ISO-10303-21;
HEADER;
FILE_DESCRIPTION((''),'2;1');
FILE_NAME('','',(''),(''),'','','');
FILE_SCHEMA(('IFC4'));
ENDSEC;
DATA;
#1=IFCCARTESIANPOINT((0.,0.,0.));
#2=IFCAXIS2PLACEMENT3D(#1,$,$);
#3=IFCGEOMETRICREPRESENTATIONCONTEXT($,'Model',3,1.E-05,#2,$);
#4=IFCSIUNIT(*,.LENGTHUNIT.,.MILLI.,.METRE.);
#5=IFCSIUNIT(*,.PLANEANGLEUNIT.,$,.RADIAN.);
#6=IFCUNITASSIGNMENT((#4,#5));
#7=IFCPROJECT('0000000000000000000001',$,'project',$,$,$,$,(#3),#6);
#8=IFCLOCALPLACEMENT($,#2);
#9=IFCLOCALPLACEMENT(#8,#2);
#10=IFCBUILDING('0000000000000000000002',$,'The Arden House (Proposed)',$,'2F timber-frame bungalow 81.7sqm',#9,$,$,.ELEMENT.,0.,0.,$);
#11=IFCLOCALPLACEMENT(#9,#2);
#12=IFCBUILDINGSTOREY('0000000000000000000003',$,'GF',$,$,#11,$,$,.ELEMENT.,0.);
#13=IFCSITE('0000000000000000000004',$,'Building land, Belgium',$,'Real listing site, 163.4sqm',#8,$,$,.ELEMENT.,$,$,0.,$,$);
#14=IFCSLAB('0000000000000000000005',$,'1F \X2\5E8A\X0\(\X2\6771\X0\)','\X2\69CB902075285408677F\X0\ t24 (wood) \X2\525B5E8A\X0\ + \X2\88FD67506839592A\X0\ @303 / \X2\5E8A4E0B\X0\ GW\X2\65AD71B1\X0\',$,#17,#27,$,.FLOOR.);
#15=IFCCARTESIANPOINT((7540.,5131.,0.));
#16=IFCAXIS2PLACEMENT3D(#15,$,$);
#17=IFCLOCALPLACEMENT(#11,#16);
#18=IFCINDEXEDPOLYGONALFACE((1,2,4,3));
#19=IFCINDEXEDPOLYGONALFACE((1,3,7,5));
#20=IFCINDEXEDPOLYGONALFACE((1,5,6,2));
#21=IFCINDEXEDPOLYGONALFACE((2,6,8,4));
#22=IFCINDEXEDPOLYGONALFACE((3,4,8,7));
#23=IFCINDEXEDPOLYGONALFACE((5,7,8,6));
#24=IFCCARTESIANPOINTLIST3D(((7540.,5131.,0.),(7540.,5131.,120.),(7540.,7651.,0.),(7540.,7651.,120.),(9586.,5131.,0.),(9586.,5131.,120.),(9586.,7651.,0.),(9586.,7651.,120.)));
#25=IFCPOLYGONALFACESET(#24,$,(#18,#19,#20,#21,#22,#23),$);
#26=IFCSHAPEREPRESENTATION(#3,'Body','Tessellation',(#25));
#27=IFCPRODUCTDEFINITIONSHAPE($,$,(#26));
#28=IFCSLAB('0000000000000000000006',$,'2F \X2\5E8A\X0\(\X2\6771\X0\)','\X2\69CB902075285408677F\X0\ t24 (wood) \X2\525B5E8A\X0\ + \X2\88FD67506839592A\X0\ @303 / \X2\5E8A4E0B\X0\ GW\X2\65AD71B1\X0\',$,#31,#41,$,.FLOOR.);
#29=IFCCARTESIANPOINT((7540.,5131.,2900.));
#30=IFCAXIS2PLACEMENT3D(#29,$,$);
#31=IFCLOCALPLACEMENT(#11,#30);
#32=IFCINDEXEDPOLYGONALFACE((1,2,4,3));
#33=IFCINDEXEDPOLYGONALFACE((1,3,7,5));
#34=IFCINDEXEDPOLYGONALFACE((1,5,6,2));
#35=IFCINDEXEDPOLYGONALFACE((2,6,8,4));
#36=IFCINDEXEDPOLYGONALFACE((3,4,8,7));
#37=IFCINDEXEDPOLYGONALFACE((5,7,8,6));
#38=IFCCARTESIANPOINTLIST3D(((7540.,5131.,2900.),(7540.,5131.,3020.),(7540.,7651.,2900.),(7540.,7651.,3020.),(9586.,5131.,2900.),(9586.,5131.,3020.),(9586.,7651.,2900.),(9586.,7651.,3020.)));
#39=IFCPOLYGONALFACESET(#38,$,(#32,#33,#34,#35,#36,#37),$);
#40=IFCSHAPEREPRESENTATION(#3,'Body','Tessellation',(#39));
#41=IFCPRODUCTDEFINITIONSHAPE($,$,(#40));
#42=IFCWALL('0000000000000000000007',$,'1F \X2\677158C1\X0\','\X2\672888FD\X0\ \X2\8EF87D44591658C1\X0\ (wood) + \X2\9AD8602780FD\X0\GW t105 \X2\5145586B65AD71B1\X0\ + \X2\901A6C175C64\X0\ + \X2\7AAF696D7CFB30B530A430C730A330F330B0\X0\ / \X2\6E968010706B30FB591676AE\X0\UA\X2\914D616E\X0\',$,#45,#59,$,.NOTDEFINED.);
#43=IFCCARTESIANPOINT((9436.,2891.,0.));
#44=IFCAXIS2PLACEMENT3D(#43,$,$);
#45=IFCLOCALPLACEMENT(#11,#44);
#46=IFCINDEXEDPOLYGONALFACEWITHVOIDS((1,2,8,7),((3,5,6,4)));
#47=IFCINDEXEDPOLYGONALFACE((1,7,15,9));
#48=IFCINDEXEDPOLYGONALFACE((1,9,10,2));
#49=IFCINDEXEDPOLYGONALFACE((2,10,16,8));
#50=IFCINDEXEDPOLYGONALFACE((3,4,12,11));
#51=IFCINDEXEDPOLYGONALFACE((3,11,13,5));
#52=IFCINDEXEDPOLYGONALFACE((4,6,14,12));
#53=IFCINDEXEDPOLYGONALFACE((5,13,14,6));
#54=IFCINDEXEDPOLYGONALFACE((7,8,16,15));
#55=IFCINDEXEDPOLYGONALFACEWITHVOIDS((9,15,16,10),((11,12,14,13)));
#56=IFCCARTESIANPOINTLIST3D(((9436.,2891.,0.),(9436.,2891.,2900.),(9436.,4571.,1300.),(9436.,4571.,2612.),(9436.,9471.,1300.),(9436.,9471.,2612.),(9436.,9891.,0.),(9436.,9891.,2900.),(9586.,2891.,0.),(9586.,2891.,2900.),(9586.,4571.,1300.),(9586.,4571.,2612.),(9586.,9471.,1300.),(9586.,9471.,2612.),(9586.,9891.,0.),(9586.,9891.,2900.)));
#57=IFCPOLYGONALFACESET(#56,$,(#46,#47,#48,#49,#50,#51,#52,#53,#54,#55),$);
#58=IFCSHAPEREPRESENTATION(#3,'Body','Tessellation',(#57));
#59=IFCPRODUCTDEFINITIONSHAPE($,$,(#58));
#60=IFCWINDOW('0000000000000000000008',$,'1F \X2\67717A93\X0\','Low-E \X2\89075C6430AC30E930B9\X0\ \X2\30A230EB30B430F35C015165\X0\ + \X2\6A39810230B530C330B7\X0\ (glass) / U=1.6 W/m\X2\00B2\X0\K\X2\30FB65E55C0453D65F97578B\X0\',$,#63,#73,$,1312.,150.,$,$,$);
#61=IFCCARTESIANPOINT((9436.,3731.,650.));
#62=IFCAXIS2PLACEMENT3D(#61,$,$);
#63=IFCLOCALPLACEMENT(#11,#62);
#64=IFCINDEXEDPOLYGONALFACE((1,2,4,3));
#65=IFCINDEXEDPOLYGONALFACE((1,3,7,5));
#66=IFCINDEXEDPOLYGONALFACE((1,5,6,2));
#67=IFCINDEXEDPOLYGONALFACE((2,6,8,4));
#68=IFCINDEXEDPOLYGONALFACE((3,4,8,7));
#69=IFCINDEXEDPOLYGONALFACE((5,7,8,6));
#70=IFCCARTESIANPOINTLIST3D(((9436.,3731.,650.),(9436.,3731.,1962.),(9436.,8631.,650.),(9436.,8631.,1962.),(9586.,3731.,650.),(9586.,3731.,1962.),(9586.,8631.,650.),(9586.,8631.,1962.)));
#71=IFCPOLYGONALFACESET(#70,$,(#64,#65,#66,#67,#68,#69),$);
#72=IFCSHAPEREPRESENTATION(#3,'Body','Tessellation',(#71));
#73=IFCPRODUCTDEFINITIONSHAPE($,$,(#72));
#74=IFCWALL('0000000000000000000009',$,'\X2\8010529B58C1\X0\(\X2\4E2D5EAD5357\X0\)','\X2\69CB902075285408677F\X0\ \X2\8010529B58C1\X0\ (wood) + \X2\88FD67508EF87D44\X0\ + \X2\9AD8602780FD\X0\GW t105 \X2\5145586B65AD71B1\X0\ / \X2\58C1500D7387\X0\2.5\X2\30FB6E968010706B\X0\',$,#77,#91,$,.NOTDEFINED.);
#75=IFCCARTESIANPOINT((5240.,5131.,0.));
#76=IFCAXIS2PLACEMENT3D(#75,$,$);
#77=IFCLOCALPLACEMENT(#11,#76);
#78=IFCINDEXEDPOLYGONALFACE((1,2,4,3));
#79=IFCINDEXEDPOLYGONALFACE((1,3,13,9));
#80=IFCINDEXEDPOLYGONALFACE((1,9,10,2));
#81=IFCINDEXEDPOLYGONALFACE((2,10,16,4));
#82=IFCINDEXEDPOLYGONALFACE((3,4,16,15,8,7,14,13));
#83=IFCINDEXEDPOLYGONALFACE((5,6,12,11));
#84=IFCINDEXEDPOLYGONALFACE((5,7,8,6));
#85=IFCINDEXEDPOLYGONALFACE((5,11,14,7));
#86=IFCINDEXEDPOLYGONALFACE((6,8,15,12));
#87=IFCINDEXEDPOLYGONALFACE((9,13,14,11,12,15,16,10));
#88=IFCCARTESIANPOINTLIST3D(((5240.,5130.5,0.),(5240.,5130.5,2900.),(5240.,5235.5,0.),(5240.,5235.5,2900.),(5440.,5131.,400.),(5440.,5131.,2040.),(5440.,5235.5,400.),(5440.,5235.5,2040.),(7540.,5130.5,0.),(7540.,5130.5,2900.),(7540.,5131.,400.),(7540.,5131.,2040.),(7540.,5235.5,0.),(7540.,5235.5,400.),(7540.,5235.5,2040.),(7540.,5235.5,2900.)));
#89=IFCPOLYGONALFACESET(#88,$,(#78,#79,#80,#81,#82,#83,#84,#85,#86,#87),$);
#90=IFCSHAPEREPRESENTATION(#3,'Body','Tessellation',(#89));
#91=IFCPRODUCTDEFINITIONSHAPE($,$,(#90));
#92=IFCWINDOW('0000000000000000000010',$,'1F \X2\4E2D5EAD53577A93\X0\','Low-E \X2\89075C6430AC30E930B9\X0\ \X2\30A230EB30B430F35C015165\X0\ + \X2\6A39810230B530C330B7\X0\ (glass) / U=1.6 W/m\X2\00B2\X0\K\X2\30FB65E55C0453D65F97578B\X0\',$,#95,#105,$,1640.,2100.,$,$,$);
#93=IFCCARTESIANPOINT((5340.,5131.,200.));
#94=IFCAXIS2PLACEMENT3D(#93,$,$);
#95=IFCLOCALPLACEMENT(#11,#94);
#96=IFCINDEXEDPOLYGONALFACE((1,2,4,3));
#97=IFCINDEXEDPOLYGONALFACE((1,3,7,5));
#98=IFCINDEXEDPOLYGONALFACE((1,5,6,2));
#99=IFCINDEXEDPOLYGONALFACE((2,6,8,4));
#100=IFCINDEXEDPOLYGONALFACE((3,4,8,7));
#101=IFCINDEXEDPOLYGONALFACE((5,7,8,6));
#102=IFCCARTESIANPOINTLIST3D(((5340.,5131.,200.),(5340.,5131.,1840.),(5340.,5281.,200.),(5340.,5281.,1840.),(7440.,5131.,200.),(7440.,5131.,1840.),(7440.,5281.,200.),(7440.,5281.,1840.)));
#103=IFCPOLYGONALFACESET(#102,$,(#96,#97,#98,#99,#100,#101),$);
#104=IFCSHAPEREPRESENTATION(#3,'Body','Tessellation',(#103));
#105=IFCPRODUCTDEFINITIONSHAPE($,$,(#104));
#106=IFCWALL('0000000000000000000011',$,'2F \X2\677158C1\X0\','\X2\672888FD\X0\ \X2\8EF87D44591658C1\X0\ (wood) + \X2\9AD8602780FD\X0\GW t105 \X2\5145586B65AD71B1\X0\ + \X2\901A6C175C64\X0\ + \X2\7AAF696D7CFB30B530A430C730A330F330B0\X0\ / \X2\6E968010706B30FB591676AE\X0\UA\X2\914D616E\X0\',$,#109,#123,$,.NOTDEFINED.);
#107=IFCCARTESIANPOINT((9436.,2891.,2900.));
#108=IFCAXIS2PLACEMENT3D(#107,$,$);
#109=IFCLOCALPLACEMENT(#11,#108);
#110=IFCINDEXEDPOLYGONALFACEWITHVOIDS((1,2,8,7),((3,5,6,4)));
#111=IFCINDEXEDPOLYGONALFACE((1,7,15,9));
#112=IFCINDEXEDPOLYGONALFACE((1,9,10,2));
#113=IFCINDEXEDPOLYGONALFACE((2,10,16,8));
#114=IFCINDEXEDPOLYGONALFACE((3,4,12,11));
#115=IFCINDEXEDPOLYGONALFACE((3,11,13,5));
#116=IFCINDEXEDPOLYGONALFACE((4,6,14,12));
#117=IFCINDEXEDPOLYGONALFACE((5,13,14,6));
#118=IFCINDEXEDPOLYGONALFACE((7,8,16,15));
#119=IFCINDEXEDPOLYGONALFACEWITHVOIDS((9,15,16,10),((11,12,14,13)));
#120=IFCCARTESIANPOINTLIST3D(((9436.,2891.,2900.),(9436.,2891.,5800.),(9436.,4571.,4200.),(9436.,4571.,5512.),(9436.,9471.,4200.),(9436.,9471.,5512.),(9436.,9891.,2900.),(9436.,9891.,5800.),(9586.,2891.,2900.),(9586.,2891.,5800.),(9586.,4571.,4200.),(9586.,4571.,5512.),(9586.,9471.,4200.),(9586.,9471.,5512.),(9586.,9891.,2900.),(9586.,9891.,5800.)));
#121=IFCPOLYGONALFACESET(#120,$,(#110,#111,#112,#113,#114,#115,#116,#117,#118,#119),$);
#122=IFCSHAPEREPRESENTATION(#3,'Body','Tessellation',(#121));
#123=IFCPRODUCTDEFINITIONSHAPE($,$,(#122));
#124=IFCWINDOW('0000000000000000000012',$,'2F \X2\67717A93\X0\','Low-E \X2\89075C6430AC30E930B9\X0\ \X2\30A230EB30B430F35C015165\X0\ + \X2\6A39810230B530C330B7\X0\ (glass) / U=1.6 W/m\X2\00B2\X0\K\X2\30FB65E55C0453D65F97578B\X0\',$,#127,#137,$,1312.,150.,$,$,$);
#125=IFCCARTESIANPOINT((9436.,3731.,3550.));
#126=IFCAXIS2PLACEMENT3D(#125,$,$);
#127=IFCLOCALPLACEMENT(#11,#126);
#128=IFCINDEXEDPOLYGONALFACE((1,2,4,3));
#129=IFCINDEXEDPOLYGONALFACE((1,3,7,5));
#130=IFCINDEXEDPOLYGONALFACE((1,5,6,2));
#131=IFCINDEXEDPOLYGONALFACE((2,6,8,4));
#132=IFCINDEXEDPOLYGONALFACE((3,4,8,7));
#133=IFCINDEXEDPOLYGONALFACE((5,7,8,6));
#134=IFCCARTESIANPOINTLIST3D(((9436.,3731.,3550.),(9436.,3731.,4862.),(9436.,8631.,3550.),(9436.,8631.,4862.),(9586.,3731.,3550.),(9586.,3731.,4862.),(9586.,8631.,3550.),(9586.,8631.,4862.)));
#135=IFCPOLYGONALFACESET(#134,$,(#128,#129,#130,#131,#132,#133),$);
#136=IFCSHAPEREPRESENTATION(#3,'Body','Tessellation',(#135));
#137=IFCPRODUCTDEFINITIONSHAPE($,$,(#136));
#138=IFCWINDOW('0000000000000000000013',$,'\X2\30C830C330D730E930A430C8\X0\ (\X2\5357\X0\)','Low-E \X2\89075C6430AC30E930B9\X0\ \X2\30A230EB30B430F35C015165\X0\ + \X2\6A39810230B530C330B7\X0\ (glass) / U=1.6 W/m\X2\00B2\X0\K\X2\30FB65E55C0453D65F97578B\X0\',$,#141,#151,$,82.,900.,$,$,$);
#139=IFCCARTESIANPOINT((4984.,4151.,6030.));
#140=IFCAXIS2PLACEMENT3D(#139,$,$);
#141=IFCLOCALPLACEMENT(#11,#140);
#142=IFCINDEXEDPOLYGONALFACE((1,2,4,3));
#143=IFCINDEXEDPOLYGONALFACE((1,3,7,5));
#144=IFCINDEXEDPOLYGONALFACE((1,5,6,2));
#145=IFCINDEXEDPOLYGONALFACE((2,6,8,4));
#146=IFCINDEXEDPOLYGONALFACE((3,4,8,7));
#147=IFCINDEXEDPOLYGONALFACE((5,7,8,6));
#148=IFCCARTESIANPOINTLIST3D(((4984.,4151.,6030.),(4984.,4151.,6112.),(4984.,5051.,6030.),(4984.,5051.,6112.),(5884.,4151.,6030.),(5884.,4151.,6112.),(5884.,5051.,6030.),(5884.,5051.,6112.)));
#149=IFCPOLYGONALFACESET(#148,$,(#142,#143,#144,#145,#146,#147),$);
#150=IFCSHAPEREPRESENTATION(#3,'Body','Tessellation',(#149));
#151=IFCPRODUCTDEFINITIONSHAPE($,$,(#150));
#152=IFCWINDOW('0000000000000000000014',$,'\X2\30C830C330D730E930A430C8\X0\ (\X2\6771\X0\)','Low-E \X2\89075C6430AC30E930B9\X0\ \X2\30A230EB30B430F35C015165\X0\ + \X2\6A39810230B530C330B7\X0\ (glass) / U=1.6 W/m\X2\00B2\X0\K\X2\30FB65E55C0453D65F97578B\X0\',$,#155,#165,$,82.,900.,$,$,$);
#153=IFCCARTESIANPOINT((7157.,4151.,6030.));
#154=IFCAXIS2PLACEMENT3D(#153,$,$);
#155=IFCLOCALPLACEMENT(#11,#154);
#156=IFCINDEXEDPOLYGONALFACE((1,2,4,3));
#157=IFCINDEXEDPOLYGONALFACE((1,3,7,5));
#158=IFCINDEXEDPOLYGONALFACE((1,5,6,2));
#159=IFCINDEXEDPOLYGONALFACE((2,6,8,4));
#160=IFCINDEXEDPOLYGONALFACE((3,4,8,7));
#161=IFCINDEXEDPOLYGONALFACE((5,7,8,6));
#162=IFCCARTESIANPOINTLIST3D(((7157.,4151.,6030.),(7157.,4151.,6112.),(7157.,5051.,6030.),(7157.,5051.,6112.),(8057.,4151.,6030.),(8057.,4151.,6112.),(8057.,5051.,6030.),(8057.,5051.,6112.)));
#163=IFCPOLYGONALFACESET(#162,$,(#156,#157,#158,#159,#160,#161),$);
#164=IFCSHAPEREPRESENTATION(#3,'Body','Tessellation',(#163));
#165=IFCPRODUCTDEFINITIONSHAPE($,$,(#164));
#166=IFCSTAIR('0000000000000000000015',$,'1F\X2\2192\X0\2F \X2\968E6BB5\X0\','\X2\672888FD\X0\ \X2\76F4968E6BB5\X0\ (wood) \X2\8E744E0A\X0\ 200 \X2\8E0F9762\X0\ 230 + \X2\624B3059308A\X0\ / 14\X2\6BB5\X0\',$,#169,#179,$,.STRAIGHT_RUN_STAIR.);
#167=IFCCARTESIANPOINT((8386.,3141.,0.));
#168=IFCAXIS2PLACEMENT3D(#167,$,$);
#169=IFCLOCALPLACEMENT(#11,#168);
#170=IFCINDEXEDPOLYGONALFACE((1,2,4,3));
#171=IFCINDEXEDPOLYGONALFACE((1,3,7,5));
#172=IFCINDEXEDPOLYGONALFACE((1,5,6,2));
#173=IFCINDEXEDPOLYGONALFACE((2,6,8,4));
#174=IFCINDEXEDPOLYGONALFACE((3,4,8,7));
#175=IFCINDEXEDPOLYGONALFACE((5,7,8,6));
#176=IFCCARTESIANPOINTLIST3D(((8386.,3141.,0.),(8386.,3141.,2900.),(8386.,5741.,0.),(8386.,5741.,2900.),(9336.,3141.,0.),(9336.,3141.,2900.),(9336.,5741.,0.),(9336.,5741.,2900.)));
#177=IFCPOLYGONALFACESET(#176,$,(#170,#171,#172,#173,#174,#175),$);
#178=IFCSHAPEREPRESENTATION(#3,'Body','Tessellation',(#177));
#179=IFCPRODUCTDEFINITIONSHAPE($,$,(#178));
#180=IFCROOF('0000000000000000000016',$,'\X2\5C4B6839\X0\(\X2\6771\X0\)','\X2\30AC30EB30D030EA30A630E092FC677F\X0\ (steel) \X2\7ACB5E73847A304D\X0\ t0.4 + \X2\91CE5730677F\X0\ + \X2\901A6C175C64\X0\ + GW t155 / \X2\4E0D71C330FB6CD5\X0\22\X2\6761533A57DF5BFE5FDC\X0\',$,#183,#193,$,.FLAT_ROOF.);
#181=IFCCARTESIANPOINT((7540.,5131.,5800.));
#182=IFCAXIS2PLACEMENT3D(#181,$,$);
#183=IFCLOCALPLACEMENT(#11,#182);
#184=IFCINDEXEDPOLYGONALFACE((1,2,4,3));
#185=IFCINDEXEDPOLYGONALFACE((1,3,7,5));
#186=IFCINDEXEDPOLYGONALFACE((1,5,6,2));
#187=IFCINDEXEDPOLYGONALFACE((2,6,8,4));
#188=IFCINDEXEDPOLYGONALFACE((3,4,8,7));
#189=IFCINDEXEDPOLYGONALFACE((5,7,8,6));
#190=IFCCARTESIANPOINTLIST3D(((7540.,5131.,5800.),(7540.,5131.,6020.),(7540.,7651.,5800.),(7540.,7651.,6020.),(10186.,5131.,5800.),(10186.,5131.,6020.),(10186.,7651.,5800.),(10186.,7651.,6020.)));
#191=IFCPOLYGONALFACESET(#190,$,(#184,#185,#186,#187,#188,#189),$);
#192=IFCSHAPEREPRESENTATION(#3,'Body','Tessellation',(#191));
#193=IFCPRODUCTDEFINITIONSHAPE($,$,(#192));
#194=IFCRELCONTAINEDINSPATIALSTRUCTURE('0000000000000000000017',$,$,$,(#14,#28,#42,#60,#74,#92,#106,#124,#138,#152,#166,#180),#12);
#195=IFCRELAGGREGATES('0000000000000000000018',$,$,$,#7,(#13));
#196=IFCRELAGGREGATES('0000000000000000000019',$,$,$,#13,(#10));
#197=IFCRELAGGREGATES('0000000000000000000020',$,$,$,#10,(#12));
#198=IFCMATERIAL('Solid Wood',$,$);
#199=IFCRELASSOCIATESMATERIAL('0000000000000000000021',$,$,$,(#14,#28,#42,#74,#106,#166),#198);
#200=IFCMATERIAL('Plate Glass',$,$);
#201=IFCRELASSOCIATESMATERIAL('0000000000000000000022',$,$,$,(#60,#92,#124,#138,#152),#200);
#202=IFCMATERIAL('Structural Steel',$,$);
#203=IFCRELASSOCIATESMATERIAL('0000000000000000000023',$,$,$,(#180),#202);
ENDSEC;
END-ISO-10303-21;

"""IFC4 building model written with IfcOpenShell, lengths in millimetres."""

from ifc_helpers import new_model, si_unit, frame, frame_2d, origin, place, context, project, spatial, rectangle, extrude, material, element, fill, save


model = new_model("IFC4")

# Units and contexts
model_context = context("Model", 3, precision=1e-05, world=origin())
ifc_project = project(units=[si_unit("LENGTHUNIT", "METRE", prefix="MILLI"), si_unit("PLANEANGLEUNIT", "RADIAN")], contexts=[model_context])

# Site, building, storey
site_placement = place(None, origin())
site = spatial("IfcSite", under=ifc_project, at=site_placement, Name="Building land, Belgium", ObjectType="Real listing site, 163.4sqm", CompositionType="ELEMENT", RefElevation=0.0)
building_placement = place(site_placement, origin())
building = spatial("IfcBuilding", under=site, at=building_placement, Name="The Arden House (Proposed)", ObjectType="2F timber-frame bungalow 81.7sqm", CompositionType="ELEMENT", ElevationOfRefHeight=0.0, ElevationOfTerrain=0.0)
storey_placement = place(building_placement, origin())
storey = spatial("IfcBuildingStorey", under=building, at=storey_placement, Name="GF", CompositionType="ELEMENT", Elevation=0.0)

# Slabs
ifc_material_1 = material(Name="Solid Wood")
slab_1_placement = place(storey_placement, frame((7540.0, 5131.0, 0.0)))
element("IfcSlab", 1, at=slab_1_placement, inside=storey, material=ifc_material_1, Name="1F 床(東)", Description="構造用合板 t24 (wood) 剛床 + 製材根太 @303 / 床下 GW断熱", PredefinedType="FLOOR", context=model_context, shape_type="SweptSolid", body=[
    extrude(rectangle(XDim=2046.0, YDim=2520.0, at=frame_2d((1023.0, 1260.0))), frame((7540.0, 5131.0, 0.0)), (0.0, 0.0, 1.0), 120.0),
])
slab_2_placement = place(storey_placement, frame((7540.0, 5131.0, 2900.0)))
element("IfcSlab", 2, at=slab_2_placement, inside=storey, material=ifc_material_1, Name="2F 床(東)", Description="構造用合板 t24 (wood) 剛床 + 製材根太 @303 / 床下 GW断熱", PredefinedType="FLOOR", context=model_context, shape_type="SweptSolid", body=[
    extrude(rectangle(XDim=2046.0, YDim=2520.0, at=frame_2d((1023.0, 1260.0))), frame((7540.0, 5131.0, 2900.0)), (0.0, 0.0, 1.0), 120.0),
])

# Walls, openings, windows
wall_1_placement = place(storey_placement, frame((9436.0, 2891.0, 0.0)))
wall_1 = element("IfcWall", 3, at=wall_1_placement, inside=storey, material=ifc_material_1, Name="1F 東壁", Description="木製 軸組外壁 (wood) + 高性能GW t105 充填断熱 + 通気層 + 窯業系サイディング / 準耐火・外皮UA配慮", PredefinedType="NOTDEFINED", context=model_context, shape_type="SweptSolid", body=[
    extrude(rectangle(XDim=150.0, YDim=7000.0, at=frame_2d((75.0, 3500.0))), frame((9436.0, 2891.0, 0.0)), (0.0, 0.0, 1.0), 2900.0),
])
opening_1_placement = place(storey_placement, frame((9436.0, 3731.0, 650.0)))
opening_1 = element("IfcOpeningElement", 4, at=opening_1_placement, cuts=wall_1, PredefinedType="NOTDEFINED", context=model_context, shape_type="SweptSolid", body=[
    extrude(rectangle(XDim=150.0, YDim=4900.0, at=frame_2d((75.0, 2450.0))), frame((9436.0, 3731.0, 650.0)), (0.0, 0.0, 1.0), 1312.0),
])
ifc_material_2 = material(Name="Plate Glass")
window_1_placement = place(storey_placement, frame((9436.0, 3731.0, 650.0)))
window_1 = element("IfcWindow", 5, at=window_1_placement, inside=storey, material=ifc_material_2, Name="1F 東窓", Description="Low-E 複層ガラス アルゴン封入 + 樹脂サッシ (glass) / U=1.6 W/m²K・日射取得型", OverallHeight=1312.0, OverallWidth=150.0, context=model_context, shape_type="SweptSolid", body=[
    extrude(rectangle(XDim=150.0, YDim=4900.0, at=frame_2d((75.0, 2450.0))), frame((9436.0, 3731.0, 650.0)), (0.0, 0.0, 1.0), 1312.0),
])
fill(opening_1, window_1)
wall_2_placement = place(storey_placement, frame((5240.0, 5131.0, 0.0)))
wall_2 = element("IfcWall", 6, at=wall_2_placement, inside=storey, material=ifc_material_1, Name="耐力壁(中庭南)", Description="構造用合板 耐力壁 (wood) + 製材軸組 + 高性能GW t105 充填断熱 / 壁倍率2.5・準耐火", PredefinedType="NOTDEFINED", context=model_context, shape_type="SweptSolid", body=[
    extrude(rectangle(XDim=2300.0, YDim=105.0, at=frame_2d((1150.0, 52.0))), frame((5240.0, 5131.0, 0.0)), (0.0, 0.0, 1.0), 2900.0),
])
opening_2_placement = place(storey_placement, frame((5340.0, 5131.0, 200.0)))
opening_2 = element("IfcOpeningElement", 7, at=opening_2_placement, cuts=wall_2, PredefinedType="NOTDEFINED", context=model_context, shape_type="SweptSolid", body=[
    extrude(rectangle(XDim=2100.0, YDim=150.0, at=frame_2d((1050.0, 75.0))), frame((5340.0, 5131.0, 200.0)), (0.0, 0.0, 1.0), 1640.0),
])
window_2_placement = place(storey_placement, frame((5340.0, 5131.0, 200.0)))
window_2 = element("IfcWindow", 8, at=window_2_placement, inside=storey, material=ifc_material_2, Name="1F 中庭南窓", Description="Low-E 複層ガラス アルゴン封入 + 樹脂サッシ (glass) / U=1.6 W/m²K・日射取得型", OverallHeight=1640.0, OverallWidth=2100.0, context=model_context, shape_type="SweptSolid", body=[
    extrude(rectangle(XDim=2100.0, YDim=150.0, at=frame_2d((1050.0, 75.0))), frame((5340.0, 5131.0, 200.0)), (0.0, 0.0, 1.0), 1640.0),
])
fill(opening_2, window_2)

# Wall, opening, window
wall_3_placement = place(storey_placement, frame((9436.0, 2891.0, 2900.0)))
wall_3 = element("IfcWall", 9, at=wall_3_placement, inside=storey, material=ifc_material_1, Name="2F 東壁", Description="木製 軸組外壁 (wood) + 高性能GW t105 充填断熱 + 通気層 + 窯業系サイディング / 準耐火・外皮UA配慮", PredefinedType="NOTDEFINED", context=model_context, shape_type="SweptSolid", body=[
    extrude(rectangle(XDim=150.0, YDim=7000.0, at=frame_2d((75.0, 3500.0))), frame((9436.0, 2891.0, 2900.0)), (0.0, 0.0, 1.0), 2900.0),
])
opening_3_placement = place(storey_placement, frame((9436.0, 3731.0, 3550.0)))
opening_3 = element("IfcOpeningElement", 10, at=opening_3_placement, cuts=wall_3, PredefinedType="NOTDEFINED", context=model_context, shape_type="SweptSolid", body=[
    extrude(rectangle(XDim=150.0, YDim=4900.0, at=frame_2d((75.0, 2450.0))), frame((9436.0, 3731.0, 3550.0)), (0.0, 0.0, 1.0), 1312.0),
])
window_3_placement = place(storey_placement, frame((9436.0, 3731.0, 3550.0)))
window_3 = element("IfcWindow", 11, at=window_3_placement, inside=storey, material=ifc_material_2, Name="2F 東窓", Description="Low-E 複層ガラス アルゴン封入 + 樹脂サッシ (glass) / U=1.6 W/m²K・日射取得型", OverallHeight=1312.0, OverallWidth=150.0, context=model_context, shape_type="SweptSolid", body=[
    extrude(rectangle(XDim=150.0, YDim=4900.0, at=frame_2d((75.0, 2450.0))), frame((9436.0, 3731.0, 3550.0)), (0.0, 0.0, 1.0), 1312.0),
])
fill(opening_3, window_3)

# Windows
window_4_placement = place(storey_placement, frame((4984.0, 4151.0, 6030.0)))
element("IfcWindow", 12, at=window_4_placement, inside=storey, material=ifc_material_2, Name="トップライト (南)", Description="Low-E 複層ガラス アルゴン封入 + 樹脂サッシ (glass) / U=1.6 W/m²K・日射取得型", OverallHeight=82.0, OverallWidth=900.0, context=model_context, shape_type="SweptSolid", body=[
    extrude(rectangle(XDim=900.0, YDim=900.0, at=frame_2d((450.0, 450.0))), frame((4984.0, 4151.0, 6030.0)), (0.0, 0.0, 1.0), 82.0),
])
window_5_placement = place(storey_placement, frame((7157.0, 4151.0, 6030.0)))
element("IfcWindow", 13, at=window_5_placement, inside=storey, material=ifc_material_2, Name="トップライト (東)", Description="Low-E 複層ガラス アルゴン封入 + 樹脂サッシ (glass) / U=1.6 W/m²K・日射取得型", OverallHeight=82.0, OverallWidth=900.0, context=model_context, shape_type="SweptSolid", body=[
    extrude(rectangle(XDim=900.0, YDim=900.0, at=frame_2d((450.0, 450.0))), frame((7157.0, 4151.0, 6030.0)), (0.0, 0.0, 1.0), 82.0),
])

# Stair
stair_placement = place(storey_placement, frame((8386.0, 3141.0, 0.0)))
element("IfcStair", 14, at=stair_placement, inside=storey, material=ifc_material_1, Name="1F→2F 階段", Description="木製 直階段 (wood) 蹴上 200 踏面 230 + 手すり / 14段", PredefinedType="STRAIGHT_RUN_STAIR", context=model_context, shape_type="SweptSolid", body=[
    extrude(rectangle(XDim=950.0, YDim=2600.0, at=frame_2d((475.0, 1300.0))), frame((8386.0, 3141.0, 0.0)), (0.0, 0.0, 1.0), 2900.0),
])

# Roof
ifc_material_3 = material(Name="Structural Steel")
roof_placement = place(storey_placement, frame((7540.0, 5131.0, 5800.0)))
element("IfcRoof", 15, at=roof_placement, inside=storey, material=ifc_material_3, Name="屋根(東)", Description="ガルバリウム鋼板 (steel) 立平葺き t0.4 + 野地板 + 通気層 + GW t155 / 不燃・法22条区域対応", PredefinedType="FLAT_ROOF", context=model_context, shape_type="SweptSolid", body=[
    extrude(rectangle(XDim=2646.0, YDim=2520.0, at=frame_2d((1323.0, 1260.0))), frame((7540.0, 5131.0, 5800.0)), (0.0, 0.0, 1.0), 220.0),
])

save(model, "model.ifc")
